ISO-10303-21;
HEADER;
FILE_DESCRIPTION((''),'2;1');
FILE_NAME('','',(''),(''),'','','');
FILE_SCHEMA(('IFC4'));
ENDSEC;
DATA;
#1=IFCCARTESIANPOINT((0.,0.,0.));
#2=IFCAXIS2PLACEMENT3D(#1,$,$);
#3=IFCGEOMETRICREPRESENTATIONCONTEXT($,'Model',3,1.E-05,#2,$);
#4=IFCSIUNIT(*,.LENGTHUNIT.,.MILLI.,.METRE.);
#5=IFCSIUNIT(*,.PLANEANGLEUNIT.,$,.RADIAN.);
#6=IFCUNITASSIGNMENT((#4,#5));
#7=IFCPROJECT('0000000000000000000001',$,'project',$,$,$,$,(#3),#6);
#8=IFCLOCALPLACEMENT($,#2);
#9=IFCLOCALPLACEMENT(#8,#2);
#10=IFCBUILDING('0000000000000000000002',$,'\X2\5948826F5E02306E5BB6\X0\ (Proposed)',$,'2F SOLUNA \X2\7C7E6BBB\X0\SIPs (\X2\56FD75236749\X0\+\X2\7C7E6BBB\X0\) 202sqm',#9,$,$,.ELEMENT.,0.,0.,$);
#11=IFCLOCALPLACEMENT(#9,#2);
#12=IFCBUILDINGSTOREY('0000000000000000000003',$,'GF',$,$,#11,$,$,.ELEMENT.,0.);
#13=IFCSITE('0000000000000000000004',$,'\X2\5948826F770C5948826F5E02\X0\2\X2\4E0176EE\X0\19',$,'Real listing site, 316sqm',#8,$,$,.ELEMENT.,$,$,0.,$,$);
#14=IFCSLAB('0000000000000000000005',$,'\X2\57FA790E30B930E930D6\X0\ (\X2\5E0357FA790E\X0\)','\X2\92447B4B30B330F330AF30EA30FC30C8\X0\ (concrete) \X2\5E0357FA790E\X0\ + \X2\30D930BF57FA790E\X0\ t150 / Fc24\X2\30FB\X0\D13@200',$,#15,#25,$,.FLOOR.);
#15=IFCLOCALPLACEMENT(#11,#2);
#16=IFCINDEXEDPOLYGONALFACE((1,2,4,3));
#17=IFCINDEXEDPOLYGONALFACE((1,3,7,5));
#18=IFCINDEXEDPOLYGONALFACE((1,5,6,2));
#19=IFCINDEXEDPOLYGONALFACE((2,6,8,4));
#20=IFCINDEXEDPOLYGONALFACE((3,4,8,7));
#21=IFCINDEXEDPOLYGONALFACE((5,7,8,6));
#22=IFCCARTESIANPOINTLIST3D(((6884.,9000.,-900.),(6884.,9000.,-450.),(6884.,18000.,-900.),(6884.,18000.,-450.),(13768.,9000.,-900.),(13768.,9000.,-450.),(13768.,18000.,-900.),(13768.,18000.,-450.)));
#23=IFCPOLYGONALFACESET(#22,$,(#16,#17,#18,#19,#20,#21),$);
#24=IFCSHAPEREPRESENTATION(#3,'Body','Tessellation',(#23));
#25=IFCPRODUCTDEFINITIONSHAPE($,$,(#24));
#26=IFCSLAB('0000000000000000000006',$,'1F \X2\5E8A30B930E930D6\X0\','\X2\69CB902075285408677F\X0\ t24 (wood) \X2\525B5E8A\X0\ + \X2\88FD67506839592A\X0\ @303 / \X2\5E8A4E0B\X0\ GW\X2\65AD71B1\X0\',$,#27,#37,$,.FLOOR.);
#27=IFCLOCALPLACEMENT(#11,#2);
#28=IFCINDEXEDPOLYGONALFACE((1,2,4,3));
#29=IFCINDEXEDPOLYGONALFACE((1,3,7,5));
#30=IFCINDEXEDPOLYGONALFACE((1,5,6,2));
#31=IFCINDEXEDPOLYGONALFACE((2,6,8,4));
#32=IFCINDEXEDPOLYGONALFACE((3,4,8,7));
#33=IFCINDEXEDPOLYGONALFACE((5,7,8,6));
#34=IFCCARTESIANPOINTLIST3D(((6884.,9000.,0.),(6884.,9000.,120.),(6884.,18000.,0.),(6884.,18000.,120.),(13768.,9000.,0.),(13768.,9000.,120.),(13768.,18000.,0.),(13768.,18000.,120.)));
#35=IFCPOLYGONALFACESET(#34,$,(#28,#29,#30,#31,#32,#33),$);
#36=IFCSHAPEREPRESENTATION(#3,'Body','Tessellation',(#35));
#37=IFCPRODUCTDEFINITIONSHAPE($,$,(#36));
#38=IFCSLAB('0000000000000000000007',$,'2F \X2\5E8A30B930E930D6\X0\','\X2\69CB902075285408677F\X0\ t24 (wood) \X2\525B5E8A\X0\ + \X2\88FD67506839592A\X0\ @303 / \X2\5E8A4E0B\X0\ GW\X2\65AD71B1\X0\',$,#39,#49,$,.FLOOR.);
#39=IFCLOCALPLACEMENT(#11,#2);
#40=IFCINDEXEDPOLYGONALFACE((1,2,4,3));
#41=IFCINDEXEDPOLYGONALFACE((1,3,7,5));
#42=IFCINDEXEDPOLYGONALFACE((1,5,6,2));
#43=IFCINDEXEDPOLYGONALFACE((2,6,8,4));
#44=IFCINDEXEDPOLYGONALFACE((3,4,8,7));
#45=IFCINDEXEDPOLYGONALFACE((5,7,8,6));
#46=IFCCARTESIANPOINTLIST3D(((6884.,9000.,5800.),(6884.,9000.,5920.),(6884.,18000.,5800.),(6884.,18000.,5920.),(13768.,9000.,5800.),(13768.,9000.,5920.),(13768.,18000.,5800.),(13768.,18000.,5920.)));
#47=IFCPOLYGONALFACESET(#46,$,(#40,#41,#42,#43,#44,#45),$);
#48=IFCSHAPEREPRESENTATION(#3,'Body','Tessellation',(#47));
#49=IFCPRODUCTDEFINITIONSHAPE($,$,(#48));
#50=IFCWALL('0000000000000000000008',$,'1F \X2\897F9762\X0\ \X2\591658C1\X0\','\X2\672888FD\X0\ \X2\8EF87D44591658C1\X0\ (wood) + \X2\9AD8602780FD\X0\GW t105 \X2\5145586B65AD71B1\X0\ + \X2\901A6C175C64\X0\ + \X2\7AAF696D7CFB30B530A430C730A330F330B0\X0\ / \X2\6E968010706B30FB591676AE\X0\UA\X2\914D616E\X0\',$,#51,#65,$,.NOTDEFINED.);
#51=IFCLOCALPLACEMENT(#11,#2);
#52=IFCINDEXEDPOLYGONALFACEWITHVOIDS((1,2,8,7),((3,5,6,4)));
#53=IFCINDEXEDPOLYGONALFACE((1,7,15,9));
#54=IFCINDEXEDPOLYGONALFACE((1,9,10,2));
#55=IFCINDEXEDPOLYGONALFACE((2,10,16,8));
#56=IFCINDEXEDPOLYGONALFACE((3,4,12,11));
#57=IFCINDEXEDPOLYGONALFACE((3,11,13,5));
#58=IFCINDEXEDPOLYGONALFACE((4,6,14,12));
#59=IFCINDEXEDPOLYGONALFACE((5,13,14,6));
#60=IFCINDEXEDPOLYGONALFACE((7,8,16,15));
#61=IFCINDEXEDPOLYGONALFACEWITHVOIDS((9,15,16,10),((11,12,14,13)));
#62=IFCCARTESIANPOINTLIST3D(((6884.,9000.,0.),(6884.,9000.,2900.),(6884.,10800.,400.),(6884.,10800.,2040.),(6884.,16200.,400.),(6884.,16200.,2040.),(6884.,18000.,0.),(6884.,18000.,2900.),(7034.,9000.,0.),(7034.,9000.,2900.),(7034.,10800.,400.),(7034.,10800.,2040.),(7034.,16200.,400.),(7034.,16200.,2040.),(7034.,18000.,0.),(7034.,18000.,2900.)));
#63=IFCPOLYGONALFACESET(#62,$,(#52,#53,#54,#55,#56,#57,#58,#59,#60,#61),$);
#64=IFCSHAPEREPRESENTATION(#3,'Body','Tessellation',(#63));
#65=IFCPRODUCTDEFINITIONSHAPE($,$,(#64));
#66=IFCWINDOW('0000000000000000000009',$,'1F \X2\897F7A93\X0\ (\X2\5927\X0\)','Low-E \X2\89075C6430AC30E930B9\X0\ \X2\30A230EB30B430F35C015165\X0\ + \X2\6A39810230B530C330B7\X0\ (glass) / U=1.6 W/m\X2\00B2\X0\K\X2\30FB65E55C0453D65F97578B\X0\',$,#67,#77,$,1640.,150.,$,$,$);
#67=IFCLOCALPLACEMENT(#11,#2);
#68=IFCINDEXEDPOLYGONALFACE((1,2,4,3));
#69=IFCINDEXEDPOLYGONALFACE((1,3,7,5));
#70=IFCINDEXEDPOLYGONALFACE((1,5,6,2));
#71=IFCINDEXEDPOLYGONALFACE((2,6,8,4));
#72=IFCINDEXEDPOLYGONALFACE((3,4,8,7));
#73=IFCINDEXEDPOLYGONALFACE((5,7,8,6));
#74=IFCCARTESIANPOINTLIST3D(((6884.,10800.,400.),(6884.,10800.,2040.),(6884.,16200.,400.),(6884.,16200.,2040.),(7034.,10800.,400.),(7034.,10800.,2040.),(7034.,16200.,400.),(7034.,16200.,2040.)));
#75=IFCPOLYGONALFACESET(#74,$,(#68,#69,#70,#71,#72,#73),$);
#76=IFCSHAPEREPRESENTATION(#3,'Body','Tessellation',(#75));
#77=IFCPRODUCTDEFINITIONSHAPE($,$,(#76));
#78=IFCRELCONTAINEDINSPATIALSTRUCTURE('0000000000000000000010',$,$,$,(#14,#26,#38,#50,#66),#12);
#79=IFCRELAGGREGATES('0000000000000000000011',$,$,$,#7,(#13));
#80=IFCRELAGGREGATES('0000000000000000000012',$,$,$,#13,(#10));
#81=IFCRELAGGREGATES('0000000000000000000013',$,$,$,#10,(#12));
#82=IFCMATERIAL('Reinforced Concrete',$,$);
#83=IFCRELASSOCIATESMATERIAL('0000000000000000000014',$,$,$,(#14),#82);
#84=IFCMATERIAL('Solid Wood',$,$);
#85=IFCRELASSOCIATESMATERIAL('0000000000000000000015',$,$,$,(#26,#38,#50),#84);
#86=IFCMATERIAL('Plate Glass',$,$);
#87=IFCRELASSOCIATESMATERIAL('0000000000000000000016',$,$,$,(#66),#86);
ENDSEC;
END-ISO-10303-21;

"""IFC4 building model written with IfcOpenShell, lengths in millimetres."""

from ifc_helpers import new_model, si_unit, frame, frame_2d, origin, place, context, project, spatial, rectangle, extrude, material, element, fill, save


model = new_model("IFC4")

# Units and contexts
model_context = context("Model", 3, precision=1e-05, world=origin())
ifc_project = project(units=[si_unit("LENGTHUNIT", "METRE", prefix="MILLI"), si_unit("PLANEANGLEUNIT", "RADIAN")], contexts=[model_context])

# Site, building, storey
site_placement = place(None, origin())
site = spatial("IfcSite", under=ifc_project, at=site_placement, Name="奈良県奈良市2丁目19", ObjectType="Real listing site, 316sqm", CompositionType="ELEMENT", RefElevation=0.0)
building_placement = place(site_placement, origin())
building = spatial("IfcBuilding", under=site, at=building_placement, Name="奈良市の家 (Proposed)", ObjectType="2F SOLUNA 籾殻SIPs (国産杉+籾殻) 202sqm", CompositionType="ELEMENT", ElevationOfRefHeight=0.0, ElevationOfTerrain=0.0)
storey_placement = place(building_placement, origin())
storey = spatial("IfcBuildingStorey", under=building, at=storey_placement, Name="GF", CompositionType="ELEMENT", Elevation=0.0)

# Slabs
ifc_material_1 = material(Name="Reinforced Concrete")
slab_1_placement = place(storey_placement, frame((3442.0, 4500.0, -450.0)))
element("IfcSlab", 1, at=slab_1_placement, inside=storey, material=ifc_material_1, Name="基礎スラブ (布基礎)", Description="鉄筋コンクリート (concrete) 布基礎 + ベタ基礎 t150 / Fc24・D13@200", PredefinedType="FLOOR", context=model_context, shape_type="SweptSolid", body=[
    extrude(rectangle(XDim=6884.0, YDim=9000.0, at=frame_2d((3442.0, 4500.0))), frame((3442.0, 4500.0, -450.0)), (0.0, 0.0, 1.0), 450.0),
])
ifc_material_2 = material(Name="Solid Wood")
slab_2_placement = place(storey_placement, frame((3442.0, 4500.0, 0.0)))
element("IfcSlab", 2, at=slab_2_placement, inside=storey, material=ifc_material_2, Name="1F 床スラブ", Description="構造用合板 t24 (wood) 剛床 + 製材根太 @303 / 床下 GW断熱", PredefinedType="FLOOR", context=model_context, shape_type="SweptSolid", body=[
    extrude(rectangle(XDim=6884.0, YDim=9000.0, at=frame_2d((3442.0, 4500.0))), frame((3442.0, 4500.0, 0.0)), (0.0, 0.0, 1.0), 120.0),
])
slab_3_placement = place(storey_placement, frame((3442.0, 4500.0, 2900.0)))
element("IfcSlab", 3, at=slab_3_placement, inside=storey, material=ifc_material_2, Name="2F 床スラブ", Description="構造用合板 t24 (wood) 剛床 + 製材根太 @303 / 床下 GW断熱", PredefinedType="FLOOR", context=model_context, shape_type="SweptSolid", body=[
    extrude(rectangle(XDim=6884.0, YDim=9000.0, at=frame_2d((3442.0, 4500.0))), frame((3442.0, 4500.0, 2900.0)), (0.0, 0.0, 1.0), 120.0),
])

# Shared definitions
ifc_material_3 = material(Name="Plate Glass")

# Wall, opening, window
wall_1_placement = place(storey_placement, frame((3442.0, 4500.0, 0.0)))
wall_1 = element("IfcWall", 4, at=wall_1_placement, inside=storey, material=ifc_material_2, Name="1F 西面 外壁", Description="木製 軸組外壁 (wood) + 高性能GW t105 充填断熱 + 通気層 + 窯業系サイディング / 準耐火・外皮UA配慮", PredefinedType="NOTDEFINED", context=model_context, shape_type="SweptSolid", body=[
    extrude(rectangle(XDim=150.0, YDim=9000.0, at=frame_2d((75.0, 4500.0))), frame((3442.0, 4500.0, 0.0)), (0.0, 0.0, 1.0), 2900.0),
])
opening_1_placement = place(storey_placement, frame((3442.0, 5400.0, 200.0)))
opening_1 = element("IfcOpeningElement", 5, at=opening_1_placement, cuts=wall_1, PredefinedType="NOTDEFINED", context=model_context, shape_type="SweptSolid", body=[
    extrude(rectangle(XDim=150.0, YDim=5400.0, at=frame_2d((75.0, 2700.0))), frame((3442.0, 5400.0, 200.0)), (0.0, 0.0, 1.0), 1640.0),
])
window_1_placement = place(storey_placement, frame((3442.0, 5400.0, 200.0)))
window_1 = element("IfcWindow", 6, at=window_1_placement, inside=storey, material=ifc_material_3, Name="1F 西窓 (大)", Description="Low-E 複層ガラス アルゴン封入 + 樹脂サッシ (glass) / U=1.6 W/m²K・日射取得型", OverallHeight=1640.0, OverallWidth=150.0, context=model_context, shape_type="SweptSolid", body=[
    extrude(rectangle(XDim=150.0, YDim=5400.0, at=frame_2d((75.0, 2700.0))), frame((3442.0, 5400.0, 200.0)), (0.0, 0.0, 1.0), 1640.0),
])
fill(opening_1, window_1)

save(model, "model.ifc")
